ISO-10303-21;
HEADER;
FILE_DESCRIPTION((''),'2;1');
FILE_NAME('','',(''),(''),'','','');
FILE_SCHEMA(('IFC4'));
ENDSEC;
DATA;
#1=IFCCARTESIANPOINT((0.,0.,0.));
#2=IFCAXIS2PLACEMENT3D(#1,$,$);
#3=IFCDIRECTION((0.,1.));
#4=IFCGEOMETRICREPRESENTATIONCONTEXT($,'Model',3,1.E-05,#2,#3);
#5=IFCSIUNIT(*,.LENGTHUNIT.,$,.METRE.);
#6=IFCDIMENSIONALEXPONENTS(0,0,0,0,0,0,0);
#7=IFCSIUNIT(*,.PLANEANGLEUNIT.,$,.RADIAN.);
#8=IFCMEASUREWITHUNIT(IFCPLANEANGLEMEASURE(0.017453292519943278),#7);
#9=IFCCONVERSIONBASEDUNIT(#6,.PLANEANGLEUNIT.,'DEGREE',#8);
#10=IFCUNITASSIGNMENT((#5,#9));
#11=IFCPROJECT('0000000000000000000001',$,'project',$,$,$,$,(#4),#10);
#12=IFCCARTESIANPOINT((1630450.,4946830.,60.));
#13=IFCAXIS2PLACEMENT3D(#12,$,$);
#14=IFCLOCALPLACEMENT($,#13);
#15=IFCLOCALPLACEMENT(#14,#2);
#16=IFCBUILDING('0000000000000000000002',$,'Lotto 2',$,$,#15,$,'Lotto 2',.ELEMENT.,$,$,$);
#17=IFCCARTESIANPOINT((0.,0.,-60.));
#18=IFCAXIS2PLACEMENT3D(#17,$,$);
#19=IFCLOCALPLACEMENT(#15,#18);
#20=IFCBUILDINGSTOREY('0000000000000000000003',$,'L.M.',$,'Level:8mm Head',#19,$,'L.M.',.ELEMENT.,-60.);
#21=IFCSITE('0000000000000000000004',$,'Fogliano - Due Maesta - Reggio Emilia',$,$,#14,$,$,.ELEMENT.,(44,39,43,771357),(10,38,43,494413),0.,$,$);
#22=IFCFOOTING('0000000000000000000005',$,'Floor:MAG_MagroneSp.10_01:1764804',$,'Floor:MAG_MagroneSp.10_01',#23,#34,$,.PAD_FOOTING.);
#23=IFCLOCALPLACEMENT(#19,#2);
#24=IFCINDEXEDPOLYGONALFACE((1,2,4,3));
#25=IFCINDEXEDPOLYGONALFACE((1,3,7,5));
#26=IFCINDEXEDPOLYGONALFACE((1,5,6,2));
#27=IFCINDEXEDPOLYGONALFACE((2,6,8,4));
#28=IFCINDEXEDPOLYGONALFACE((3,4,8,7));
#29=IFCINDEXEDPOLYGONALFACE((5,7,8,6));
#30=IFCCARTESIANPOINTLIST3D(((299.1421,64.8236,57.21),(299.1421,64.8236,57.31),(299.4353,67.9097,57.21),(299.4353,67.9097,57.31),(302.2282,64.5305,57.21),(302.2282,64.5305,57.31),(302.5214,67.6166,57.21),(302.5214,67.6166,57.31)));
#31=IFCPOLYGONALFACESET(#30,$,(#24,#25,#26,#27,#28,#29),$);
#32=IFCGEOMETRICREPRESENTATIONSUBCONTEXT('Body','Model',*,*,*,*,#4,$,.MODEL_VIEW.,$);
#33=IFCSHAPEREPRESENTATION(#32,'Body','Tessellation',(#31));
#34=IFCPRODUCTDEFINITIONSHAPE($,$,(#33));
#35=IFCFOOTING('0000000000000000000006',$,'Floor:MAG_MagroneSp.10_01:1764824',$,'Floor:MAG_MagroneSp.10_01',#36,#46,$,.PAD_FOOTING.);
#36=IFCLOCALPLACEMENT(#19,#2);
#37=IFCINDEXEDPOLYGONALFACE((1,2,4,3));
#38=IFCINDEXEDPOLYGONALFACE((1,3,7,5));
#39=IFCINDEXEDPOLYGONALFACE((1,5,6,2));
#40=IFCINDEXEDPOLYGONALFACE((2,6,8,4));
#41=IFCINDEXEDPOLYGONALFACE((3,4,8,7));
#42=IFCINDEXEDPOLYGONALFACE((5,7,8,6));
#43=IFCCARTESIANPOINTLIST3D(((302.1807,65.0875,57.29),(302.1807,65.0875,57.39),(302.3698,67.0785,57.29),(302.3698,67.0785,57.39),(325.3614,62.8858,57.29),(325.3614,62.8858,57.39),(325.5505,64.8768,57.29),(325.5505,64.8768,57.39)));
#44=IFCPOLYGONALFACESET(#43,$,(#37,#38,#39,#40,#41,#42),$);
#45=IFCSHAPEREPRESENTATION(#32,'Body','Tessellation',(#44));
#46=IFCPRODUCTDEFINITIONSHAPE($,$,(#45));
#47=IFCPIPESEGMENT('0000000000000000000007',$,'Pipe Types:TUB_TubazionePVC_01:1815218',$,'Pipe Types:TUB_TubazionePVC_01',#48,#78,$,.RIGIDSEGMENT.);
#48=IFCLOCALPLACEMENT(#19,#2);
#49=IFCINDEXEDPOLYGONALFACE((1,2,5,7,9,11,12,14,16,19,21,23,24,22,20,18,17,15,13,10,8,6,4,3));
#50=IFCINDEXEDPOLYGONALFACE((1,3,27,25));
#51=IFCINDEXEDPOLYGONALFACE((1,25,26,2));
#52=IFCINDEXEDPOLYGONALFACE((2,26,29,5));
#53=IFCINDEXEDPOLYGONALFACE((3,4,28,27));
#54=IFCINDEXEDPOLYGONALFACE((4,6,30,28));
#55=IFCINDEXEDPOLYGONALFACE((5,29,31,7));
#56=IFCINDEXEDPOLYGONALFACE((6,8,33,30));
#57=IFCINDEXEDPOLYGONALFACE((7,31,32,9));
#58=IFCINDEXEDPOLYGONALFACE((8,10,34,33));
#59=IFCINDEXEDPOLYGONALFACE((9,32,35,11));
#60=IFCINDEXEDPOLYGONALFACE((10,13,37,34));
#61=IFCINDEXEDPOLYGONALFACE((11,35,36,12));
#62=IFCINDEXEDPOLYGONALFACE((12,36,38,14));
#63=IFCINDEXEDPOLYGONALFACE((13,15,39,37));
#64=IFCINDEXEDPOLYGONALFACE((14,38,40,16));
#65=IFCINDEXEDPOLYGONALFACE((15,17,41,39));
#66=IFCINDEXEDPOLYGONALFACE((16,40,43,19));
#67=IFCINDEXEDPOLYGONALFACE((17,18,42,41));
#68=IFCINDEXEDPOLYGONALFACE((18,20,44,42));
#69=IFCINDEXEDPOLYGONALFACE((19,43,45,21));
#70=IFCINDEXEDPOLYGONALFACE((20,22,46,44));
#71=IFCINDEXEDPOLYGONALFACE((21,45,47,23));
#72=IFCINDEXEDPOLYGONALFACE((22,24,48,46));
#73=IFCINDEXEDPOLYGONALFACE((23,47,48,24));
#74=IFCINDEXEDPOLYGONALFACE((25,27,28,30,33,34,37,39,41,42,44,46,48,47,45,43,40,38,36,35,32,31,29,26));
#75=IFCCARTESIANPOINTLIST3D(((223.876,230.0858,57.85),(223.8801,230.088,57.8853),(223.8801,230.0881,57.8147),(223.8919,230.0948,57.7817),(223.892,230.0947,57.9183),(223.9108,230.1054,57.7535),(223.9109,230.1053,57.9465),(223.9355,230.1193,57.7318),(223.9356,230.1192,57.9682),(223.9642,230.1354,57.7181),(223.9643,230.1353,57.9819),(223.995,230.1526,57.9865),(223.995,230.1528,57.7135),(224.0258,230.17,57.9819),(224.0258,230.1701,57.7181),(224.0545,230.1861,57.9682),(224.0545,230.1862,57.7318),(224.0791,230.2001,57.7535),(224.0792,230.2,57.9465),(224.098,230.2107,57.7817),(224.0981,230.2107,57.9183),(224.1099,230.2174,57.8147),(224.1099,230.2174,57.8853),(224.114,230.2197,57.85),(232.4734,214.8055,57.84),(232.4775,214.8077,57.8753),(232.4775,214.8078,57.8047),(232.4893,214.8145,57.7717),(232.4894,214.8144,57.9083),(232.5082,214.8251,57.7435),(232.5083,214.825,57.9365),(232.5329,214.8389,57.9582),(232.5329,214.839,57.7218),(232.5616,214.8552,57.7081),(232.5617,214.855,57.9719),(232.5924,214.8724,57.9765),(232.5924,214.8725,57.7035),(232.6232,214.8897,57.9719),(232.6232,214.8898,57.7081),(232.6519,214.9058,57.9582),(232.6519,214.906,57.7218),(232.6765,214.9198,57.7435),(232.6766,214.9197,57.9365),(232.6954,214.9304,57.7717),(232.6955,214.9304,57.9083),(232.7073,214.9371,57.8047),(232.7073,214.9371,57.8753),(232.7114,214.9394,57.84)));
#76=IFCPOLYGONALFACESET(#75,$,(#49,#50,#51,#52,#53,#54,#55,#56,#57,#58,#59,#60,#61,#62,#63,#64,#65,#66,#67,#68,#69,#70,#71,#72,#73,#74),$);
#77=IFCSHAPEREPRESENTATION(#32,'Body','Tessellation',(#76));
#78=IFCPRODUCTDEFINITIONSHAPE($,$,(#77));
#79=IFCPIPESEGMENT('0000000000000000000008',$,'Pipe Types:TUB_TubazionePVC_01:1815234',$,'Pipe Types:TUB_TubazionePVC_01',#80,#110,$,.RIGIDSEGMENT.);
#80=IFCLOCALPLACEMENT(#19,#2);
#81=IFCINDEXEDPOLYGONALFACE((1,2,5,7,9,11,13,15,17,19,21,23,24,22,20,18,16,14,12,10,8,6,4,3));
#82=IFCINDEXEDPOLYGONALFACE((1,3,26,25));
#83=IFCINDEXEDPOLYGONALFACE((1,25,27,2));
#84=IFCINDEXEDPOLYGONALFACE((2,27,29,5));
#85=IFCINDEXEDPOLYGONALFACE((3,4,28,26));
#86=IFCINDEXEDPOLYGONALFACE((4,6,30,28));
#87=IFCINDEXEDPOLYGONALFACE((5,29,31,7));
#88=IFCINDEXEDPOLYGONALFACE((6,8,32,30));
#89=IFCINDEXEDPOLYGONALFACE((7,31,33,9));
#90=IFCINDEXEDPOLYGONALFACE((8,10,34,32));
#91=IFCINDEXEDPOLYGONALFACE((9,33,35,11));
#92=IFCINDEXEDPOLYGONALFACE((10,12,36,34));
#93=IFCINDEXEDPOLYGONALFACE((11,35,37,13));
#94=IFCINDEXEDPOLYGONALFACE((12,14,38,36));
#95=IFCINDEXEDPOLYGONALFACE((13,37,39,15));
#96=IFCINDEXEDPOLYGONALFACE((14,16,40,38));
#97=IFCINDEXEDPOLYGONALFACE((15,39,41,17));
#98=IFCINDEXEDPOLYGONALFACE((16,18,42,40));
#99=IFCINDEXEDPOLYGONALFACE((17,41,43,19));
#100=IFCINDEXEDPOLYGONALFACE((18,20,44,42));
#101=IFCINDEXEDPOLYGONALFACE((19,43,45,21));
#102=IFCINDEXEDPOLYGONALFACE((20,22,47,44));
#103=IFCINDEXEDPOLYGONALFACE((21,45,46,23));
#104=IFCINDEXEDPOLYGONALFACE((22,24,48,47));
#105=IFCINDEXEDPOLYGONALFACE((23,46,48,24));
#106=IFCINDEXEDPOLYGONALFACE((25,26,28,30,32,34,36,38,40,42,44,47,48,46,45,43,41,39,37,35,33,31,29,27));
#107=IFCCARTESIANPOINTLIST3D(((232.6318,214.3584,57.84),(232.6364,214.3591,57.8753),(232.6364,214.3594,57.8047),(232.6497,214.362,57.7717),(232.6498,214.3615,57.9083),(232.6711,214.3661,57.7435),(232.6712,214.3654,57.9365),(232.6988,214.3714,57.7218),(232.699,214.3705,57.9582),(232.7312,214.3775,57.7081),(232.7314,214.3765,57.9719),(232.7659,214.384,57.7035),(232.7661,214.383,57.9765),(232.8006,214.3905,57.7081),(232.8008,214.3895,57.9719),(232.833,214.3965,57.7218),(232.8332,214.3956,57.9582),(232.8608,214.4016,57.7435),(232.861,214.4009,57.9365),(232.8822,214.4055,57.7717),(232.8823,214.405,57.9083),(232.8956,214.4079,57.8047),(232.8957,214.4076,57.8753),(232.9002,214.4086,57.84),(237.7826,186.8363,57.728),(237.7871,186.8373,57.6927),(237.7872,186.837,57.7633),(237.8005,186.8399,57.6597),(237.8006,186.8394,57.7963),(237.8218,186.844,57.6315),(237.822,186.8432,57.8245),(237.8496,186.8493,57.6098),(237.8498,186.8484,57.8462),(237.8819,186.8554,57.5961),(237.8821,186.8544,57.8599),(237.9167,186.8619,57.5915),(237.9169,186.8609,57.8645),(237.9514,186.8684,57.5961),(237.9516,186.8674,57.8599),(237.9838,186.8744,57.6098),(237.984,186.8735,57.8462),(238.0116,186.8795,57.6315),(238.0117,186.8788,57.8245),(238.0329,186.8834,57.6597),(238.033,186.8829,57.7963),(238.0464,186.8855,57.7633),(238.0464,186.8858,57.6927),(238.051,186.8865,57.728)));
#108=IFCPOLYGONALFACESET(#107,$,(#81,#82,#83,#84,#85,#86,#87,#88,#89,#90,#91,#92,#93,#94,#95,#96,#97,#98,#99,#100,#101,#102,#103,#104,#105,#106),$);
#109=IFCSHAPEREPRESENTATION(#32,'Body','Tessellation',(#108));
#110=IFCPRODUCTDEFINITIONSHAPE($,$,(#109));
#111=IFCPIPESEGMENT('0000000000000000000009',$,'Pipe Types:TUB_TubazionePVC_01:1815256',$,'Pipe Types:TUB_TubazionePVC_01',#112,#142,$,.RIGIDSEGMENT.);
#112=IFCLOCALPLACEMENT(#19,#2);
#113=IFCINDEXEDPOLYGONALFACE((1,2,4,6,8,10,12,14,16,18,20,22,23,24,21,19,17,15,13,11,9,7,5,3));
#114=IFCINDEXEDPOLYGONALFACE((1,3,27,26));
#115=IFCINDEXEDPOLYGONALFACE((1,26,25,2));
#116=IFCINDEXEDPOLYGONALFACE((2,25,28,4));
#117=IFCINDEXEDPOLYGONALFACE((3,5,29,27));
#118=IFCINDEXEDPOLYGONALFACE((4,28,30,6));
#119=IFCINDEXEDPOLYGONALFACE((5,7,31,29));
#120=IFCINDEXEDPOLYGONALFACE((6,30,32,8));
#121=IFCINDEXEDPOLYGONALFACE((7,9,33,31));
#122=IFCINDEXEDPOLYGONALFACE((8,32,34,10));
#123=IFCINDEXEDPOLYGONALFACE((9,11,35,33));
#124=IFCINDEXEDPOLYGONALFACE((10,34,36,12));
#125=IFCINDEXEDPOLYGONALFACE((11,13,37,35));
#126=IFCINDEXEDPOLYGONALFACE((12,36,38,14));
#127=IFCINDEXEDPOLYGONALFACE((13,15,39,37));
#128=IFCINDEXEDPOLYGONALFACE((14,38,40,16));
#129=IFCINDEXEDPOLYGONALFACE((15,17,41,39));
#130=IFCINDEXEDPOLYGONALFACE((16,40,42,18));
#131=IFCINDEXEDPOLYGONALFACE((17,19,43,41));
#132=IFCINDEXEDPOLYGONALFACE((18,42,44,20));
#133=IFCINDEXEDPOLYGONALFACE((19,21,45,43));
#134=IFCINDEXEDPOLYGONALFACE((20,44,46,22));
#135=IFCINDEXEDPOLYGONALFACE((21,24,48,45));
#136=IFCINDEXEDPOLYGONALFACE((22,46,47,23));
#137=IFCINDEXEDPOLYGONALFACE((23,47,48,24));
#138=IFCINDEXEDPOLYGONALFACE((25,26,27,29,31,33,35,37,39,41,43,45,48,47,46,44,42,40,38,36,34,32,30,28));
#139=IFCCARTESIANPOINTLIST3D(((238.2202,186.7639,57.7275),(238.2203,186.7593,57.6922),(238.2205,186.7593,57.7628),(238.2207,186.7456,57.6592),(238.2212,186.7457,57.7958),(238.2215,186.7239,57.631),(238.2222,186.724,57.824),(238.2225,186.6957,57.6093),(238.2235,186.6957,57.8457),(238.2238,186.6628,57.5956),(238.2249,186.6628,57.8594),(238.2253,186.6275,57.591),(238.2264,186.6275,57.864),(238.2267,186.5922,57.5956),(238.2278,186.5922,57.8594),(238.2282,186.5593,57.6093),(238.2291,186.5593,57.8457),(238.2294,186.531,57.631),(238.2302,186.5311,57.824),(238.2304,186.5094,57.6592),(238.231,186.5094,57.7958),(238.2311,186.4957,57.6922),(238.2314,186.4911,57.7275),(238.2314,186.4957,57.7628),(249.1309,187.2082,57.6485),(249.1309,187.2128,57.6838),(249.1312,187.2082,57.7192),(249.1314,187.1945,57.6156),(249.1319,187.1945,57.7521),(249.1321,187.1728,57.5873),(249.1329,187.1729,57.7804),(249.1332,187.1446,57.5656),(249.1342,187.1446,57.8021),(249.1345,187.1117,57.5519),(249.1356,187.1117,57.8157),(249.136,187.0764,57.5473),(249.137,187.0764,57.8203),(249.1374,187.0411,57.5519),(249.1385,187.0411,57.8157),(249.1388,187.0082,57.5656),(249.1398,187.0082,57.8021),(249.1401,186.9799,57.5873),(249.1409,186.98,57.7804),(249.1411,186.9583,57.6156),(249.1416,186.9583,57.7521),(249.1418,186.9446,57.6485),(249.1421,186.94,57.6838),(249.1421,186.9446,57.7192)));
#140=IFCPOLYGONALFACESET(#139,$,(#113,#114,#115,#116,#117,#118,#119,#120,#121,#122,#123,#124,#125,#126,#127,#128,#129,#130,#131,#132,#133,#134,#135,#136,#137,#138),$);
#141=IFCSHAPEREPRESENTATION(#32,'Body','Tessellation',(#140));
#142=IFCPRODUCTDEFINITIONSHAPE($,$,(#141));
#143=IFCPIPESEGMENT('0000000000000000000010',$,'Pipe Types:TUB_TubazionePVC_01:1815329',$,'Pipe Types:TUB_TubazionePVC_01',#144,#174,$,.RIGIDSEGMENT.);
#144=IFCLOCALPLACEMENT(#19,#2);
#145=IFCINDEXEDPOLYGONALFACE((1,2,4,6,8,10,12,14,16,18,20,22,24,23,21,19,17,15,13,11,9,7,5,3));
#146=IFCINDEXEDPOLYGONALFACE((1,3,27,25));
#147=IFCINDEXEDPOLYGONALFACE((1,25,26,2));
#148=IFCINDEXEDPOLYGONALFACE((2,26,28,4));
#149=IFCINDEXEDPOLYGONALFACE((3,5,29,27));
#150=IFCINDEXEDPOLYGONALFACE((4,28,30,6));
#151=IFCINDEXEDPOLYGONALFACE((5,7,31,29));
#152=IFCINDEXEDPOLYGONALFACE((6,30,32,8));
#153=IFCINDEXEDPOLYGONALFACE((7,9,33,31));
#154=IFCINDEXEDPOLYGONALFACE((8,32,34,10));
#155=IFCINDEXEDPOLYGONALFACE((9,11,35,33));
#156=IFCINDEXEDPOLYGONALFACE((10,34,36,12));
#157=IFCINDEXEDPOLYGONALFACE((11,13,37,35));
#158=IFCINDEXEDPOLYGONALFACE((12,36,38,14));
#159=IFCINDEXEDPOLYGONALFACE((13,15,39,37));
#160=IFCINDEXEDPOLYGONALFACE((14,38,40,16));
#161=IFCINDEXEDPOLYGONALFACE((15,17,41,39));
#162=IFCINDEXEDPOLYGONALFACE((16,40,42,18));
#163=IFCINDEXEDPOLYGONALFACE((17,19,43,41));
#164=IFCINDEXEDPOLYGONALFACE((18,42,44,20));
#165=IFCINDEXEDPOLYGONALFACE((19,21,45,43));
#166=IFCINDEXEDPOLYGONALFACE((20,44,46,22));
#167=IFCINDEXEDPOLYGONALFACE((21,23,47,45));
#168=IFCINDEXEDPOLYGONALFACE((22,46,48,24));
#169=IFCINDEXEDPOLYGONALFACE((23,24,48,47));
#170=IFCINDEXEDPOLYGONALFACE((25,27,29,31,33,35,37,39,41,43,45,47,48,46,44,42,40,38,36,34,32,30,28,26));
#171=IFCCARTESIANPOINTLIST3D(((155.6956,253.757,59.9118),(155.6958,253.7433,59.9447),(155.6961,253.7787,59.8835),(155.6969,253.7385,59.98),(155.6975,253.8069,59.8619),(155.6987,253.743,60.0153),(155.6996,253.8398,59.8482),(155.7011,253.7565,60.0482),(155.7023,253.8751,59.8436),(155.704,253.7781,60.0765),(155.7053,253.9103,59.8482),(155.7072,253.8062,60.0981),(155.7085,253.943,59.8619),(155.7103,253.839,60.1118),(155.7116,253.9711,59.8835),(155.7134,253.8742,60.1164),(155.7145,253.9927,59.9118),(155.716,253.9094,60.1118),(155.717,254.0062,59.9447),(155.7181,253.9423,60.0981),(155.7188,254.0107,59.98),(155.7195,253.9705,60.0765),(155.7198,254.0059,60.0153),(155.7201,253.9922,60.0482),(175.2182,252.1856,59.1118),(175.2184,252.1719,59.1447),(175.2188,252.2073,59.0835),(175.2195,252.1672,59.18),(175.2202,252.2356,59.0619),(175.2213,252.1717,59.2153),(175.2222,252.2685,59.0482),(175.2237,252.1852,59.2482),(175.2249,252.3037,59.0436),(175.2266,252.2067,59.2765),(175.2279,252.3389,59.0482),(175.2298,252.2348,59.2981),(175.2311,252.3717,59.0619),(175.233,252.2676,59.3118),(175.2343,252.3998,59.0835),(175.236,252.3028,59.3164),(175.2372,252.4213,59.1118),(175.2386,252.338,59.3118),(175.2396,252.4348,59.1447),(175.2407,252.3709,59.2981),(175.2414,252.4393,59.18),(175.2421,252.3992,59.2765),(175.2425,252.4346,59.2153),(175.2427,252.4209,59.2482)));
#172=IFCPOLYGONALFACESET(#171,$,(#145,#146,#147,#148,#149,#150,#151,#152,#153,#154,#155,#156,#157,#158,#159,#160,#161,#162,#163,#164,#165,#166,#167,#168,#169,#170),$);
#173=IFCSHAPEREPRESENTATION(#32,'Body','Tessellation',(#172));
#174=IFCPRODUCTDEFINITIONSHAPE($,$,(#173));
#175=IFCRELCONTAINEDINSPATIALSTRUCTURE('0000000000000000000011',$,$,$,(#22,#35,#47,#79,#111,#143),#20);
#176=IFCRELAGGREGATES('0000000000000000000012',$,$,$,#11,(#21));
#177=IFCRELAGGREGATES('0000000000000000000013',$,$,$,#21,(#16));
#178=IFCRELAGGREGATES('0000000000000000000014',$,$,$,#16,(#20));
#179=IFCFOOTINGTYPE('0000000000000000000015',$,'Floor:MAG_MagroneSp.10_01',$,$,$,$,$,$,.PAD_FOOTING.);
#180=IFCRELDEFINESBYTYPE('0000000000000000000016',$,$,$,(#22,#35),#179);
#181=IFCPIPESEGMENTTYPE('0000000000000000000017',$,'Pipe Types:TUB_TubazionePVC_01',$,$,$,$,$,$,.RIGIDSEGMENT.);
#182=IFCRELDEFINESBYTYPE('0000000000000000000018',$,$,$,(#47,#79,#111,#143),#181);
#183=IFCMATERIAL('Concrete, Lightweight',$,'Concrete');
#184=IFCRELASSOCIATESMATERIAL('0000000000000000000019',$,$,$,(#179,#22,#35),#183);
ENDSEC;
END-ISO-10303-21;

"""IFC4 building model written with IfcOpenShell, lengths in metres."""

from ifc_helpers import new_model, entity, si_unit, converted_unit, direction, frame, origin, place, context, subcontext, project, spatial, arc, indexed_curve, outline, extrude, material, type_object, element, save


model = new_model("IFC4")

# Units and contexts
model_context = context("Model", 3, precision=1e-05, world=origin(), true_north=direction((0.0, 1.0)))
body_context = subcontext(model_context, "Body", "Model", "MODEL_VIEW")
ifc_project = project(units=[si_unit("LENGTHUNIT", "METRE"), converted_unit("PLANEANGLEUNIT", "DEGREE", entity("IfcPlaneAngleMeasure", 0.017453292519943278), si_unit("PLANEANGLEUNIT", "RADIAN"), dimensions=[0, 0, 0, 0, 0, 0, 0])], contexts=[model_context])

# Site, building, storey
site_placement = place(None, frame((1630450.0, 4946830.0, 60.0)))
site = spatial("IfcSite", under=ifc_project, at=site_placement, Name="Fogliano - Due Maesta - Reggio Emilia", CompositionType="ELEMENT", RefLatitude=(44, 39, 43, 771357), RefLongitude=(10, 38, 43, 494413), RefElevation=0.0)
building_placement = place(site_placement, origin())
building = spatial("IfcBuilding", under=site, at=building_placement, Name="Lotto 2", LongName="Lotto 2", CompositionType="ELEMENT")
storey_placement = place(building_placement, frame((0.0, 0.0, -60.0)))
storey = spatial("IfcBuildingStorey", under=building, at=storey_placement, Name="L.M.", ObjectType="Level:8mm Head", LongName="L.M.", CompositionType="ELEMENT", Elevation=-60.0)

# Footings
ifc_material = material(Name="Concrete, Lightweight", Category="Concrete")
footing_type = type_object("IfcFootingType", Name="Floor:MAG_MagroneSp.10_01", PredefinedType="PAD_FOOTING", material=ifc_material)
footing_1_placement = place(storey_placement, origin())
element("IfcFooting", 1, at=footing_1_placement, inside=storey, type_object=footing_type, material=ifc_material, Name="Floor:MAG_MagroneSp.10_01:1764804", ObjectType="Floor:MAG_MagroneSp.10_01", PredefinedType="PAD_FOOTING", context=body_context, shape_type="SweptSolid", body=[
    extrude(outline(indexed_curve([(-1.55, -1.55), (1.55, -1.55), (1.55, 1.55), (-1.55, 1.55), (-1.55, -1.55)], self_intersect=False)), frame((300.8317, 66.2201, 57.31), z_axis=(0.0, 0.0, -1.0), x_axis=(-0.094555, -0.99552, 0.0)), (0.0, 0.0, 1.0), 0.1),
])
footing_2_placement = place(storey_placement, origin())
element("IfcFooting", 2, at=footing_2_placement, inside=storey, type_object=footing_type, material=ifc_material, Name="Floor:MAG_MagroneSp.10_01:1764824", ObjectType="Floor:MAG_MagroneSp.10_01", PredefinedType="PAD_FOOTING", context=body_context, shape_type="SweptSolid", body=[
    extrude(outline(indexed_curve([(-11.6425, -1.0), (11.6425, -1.0), (11.6425, 1.0), (-11.6425, 1.0), (-11.6425, -1.0)], self_intersect=False)), frame((313.8656, 64.9821, 57.39), z_axis=(0.0, 0.0, -1.0), x_axis=(0.99552, -0.094555, 0.0)), (0.0, 0.0, 1.0), 0.1),
])

# Pipe segments
pipe_segment_type = type_object("IfcPipeSegmentType", Name="Pipe Types:TUB_TubazionePVC_01", PredefinedType="RIGIDSEGMENT")
pipe_segment_1_placement = place(storey_placement, origin())
element("IfcPipeSegment", 3, at=pipe_segment_1_placement, inside=storey, type_object=pipe_segment_type, Name="Pipe Types:TUB_TubazionePVC_01:1815218", ObjectType="Pipe Types:TUB_TubazionePVC_01", PredefinedType="RIGIDSEGMENT", context=body_context, shape_type="SweptSolid", body=[
    extrude(outline(indexed_curve([(0.1365, 0.0), (0.0965, 0.0965), (0.0, 0.1365), (-0.0965, 0.0965), (-0.1365, 0.0), (-0.0965, -0.0965), (0.0, -0.1365), (0.0965, -0.0965)], segments=[arc(1, 2, 3), arc(3, 4, 5), arc(5, 6, 7), arc(7, 8, 1)], self_intersect=False)), frame((223.995, 230.1527, 57.85), z_axis=(0.490358, -0.871521, -0.00057), x_axis=(-0.871521, -0.490358, 0.0)), (0.0, 0.0, 1.0), 17.5329),
])
pipe_segment_2_placement = place(storey_placement, origin())
element("IfcPipeSegment", 4, at=pipe_segment_2_placement, inside=storey, type_object=pipe_segment_type, Name="Pipe Types:TUB_TubazionePVC_01:1815234", ObjectType="Pipe Types:TUB_TubazionePVC_01", PredefinedType="RIGIDSEGMENT", context=body_context, shape_type="SweptSolid", body=[
    extrude(outline(indexed_curve([(0.1365, 0.0), (0.0965, 0.0965), (0.0, 0.1365), (-0.0965, 0.0965), (-0.1365, 0.0), (-0.0965, -0.0965), (0.0, -0.1365), (0.0965, -0.0965)], segments=[arc(1, 2, 3), arc(3, 4, 5), arc(5, 6, 7), arc(7, 8, 1)], self_intersect=False)), frame((237.9168, 186.8614, 57.728), z_axis=(-0.183955, 0.982927, 0.004), x_axis=(-0.982934, -0.183956, 0.0)), (0.0, 0.0, 1.0), 28.0002),
])
pipe_segment_3_placement = place(storey_placement, origin())
element("IfcPipeSegment", 5, at=pipe_segment_3_placement, inside=storey, type_object=pipe_segment_type, Name="Pipe Types:TUB_TubazionePVC_01:1815256", ObjectType="Pipe Types:TUB_TubazionePVC_01", PredefinedType="RIGIDSEGMENT", context=body_context, shape_type="SweptSolid", body=[
    extrude(outline(indexed_curve([(0.1365, 0.0), (0.0965, 0.0965), (0.0, 0.1365), (-0.0965, 0.0965), (-0.1365, 0.0), (-0.0965, -0.0965), (0.0, -0.1365), (0.0965, -0.0965)], segments=[arc(1, 2, 3), arc(3, 4, 5), arc(5, 6, 7), arc(7, 8, 1)], self_intersect=False)), frame((238.2258, 186.6275, 57.7275), z_axis=(0.999147, 0.041107, -0.004), x_axis=(0.041108, -0.999155, 0.0)), (0.0, 0.0, 1.0), 10.92),
])
pipe_segment_4_placement = place(storey_placement, origin())
element("IfcPipeSegment", 6, at=pipe_segment_4_placement, inside=storey, type_object=pipe_segment_type, Name="Pipe Types:TUB_TubazionePVC_01:1815329", ObjectType="Pipe Types:TUB_TubazionePVC_01", PredefinedType="RIGIDSEGMENT", context=body_context, shape_type="SweptSolid", body=[
    extrude(outline(indexed_curve([(0.1365, 0.0), (0.0965, 0.0965), (0.0, 0.1365), (-0.0965, 0.0965), (-0.1365, 0.0), (-0.0965, -0.0965), (0.0, -0.1365), (0.0965, -0.0965)], segments=[arc(1, 2, 3), arc(3, 4, 5), arc(5, 6, 7), arc(7, 8, 1)], self_intersect=False)), frame((155.7078, 253.8746, 59.98), z_axis=(0.995946, -0.080163, -0.040812), x_axis=(0.08023, 0.996776, 0.0)), (0.0, 0.0, 1.0), 19.6021),
])

save(model, "model.ifc")
